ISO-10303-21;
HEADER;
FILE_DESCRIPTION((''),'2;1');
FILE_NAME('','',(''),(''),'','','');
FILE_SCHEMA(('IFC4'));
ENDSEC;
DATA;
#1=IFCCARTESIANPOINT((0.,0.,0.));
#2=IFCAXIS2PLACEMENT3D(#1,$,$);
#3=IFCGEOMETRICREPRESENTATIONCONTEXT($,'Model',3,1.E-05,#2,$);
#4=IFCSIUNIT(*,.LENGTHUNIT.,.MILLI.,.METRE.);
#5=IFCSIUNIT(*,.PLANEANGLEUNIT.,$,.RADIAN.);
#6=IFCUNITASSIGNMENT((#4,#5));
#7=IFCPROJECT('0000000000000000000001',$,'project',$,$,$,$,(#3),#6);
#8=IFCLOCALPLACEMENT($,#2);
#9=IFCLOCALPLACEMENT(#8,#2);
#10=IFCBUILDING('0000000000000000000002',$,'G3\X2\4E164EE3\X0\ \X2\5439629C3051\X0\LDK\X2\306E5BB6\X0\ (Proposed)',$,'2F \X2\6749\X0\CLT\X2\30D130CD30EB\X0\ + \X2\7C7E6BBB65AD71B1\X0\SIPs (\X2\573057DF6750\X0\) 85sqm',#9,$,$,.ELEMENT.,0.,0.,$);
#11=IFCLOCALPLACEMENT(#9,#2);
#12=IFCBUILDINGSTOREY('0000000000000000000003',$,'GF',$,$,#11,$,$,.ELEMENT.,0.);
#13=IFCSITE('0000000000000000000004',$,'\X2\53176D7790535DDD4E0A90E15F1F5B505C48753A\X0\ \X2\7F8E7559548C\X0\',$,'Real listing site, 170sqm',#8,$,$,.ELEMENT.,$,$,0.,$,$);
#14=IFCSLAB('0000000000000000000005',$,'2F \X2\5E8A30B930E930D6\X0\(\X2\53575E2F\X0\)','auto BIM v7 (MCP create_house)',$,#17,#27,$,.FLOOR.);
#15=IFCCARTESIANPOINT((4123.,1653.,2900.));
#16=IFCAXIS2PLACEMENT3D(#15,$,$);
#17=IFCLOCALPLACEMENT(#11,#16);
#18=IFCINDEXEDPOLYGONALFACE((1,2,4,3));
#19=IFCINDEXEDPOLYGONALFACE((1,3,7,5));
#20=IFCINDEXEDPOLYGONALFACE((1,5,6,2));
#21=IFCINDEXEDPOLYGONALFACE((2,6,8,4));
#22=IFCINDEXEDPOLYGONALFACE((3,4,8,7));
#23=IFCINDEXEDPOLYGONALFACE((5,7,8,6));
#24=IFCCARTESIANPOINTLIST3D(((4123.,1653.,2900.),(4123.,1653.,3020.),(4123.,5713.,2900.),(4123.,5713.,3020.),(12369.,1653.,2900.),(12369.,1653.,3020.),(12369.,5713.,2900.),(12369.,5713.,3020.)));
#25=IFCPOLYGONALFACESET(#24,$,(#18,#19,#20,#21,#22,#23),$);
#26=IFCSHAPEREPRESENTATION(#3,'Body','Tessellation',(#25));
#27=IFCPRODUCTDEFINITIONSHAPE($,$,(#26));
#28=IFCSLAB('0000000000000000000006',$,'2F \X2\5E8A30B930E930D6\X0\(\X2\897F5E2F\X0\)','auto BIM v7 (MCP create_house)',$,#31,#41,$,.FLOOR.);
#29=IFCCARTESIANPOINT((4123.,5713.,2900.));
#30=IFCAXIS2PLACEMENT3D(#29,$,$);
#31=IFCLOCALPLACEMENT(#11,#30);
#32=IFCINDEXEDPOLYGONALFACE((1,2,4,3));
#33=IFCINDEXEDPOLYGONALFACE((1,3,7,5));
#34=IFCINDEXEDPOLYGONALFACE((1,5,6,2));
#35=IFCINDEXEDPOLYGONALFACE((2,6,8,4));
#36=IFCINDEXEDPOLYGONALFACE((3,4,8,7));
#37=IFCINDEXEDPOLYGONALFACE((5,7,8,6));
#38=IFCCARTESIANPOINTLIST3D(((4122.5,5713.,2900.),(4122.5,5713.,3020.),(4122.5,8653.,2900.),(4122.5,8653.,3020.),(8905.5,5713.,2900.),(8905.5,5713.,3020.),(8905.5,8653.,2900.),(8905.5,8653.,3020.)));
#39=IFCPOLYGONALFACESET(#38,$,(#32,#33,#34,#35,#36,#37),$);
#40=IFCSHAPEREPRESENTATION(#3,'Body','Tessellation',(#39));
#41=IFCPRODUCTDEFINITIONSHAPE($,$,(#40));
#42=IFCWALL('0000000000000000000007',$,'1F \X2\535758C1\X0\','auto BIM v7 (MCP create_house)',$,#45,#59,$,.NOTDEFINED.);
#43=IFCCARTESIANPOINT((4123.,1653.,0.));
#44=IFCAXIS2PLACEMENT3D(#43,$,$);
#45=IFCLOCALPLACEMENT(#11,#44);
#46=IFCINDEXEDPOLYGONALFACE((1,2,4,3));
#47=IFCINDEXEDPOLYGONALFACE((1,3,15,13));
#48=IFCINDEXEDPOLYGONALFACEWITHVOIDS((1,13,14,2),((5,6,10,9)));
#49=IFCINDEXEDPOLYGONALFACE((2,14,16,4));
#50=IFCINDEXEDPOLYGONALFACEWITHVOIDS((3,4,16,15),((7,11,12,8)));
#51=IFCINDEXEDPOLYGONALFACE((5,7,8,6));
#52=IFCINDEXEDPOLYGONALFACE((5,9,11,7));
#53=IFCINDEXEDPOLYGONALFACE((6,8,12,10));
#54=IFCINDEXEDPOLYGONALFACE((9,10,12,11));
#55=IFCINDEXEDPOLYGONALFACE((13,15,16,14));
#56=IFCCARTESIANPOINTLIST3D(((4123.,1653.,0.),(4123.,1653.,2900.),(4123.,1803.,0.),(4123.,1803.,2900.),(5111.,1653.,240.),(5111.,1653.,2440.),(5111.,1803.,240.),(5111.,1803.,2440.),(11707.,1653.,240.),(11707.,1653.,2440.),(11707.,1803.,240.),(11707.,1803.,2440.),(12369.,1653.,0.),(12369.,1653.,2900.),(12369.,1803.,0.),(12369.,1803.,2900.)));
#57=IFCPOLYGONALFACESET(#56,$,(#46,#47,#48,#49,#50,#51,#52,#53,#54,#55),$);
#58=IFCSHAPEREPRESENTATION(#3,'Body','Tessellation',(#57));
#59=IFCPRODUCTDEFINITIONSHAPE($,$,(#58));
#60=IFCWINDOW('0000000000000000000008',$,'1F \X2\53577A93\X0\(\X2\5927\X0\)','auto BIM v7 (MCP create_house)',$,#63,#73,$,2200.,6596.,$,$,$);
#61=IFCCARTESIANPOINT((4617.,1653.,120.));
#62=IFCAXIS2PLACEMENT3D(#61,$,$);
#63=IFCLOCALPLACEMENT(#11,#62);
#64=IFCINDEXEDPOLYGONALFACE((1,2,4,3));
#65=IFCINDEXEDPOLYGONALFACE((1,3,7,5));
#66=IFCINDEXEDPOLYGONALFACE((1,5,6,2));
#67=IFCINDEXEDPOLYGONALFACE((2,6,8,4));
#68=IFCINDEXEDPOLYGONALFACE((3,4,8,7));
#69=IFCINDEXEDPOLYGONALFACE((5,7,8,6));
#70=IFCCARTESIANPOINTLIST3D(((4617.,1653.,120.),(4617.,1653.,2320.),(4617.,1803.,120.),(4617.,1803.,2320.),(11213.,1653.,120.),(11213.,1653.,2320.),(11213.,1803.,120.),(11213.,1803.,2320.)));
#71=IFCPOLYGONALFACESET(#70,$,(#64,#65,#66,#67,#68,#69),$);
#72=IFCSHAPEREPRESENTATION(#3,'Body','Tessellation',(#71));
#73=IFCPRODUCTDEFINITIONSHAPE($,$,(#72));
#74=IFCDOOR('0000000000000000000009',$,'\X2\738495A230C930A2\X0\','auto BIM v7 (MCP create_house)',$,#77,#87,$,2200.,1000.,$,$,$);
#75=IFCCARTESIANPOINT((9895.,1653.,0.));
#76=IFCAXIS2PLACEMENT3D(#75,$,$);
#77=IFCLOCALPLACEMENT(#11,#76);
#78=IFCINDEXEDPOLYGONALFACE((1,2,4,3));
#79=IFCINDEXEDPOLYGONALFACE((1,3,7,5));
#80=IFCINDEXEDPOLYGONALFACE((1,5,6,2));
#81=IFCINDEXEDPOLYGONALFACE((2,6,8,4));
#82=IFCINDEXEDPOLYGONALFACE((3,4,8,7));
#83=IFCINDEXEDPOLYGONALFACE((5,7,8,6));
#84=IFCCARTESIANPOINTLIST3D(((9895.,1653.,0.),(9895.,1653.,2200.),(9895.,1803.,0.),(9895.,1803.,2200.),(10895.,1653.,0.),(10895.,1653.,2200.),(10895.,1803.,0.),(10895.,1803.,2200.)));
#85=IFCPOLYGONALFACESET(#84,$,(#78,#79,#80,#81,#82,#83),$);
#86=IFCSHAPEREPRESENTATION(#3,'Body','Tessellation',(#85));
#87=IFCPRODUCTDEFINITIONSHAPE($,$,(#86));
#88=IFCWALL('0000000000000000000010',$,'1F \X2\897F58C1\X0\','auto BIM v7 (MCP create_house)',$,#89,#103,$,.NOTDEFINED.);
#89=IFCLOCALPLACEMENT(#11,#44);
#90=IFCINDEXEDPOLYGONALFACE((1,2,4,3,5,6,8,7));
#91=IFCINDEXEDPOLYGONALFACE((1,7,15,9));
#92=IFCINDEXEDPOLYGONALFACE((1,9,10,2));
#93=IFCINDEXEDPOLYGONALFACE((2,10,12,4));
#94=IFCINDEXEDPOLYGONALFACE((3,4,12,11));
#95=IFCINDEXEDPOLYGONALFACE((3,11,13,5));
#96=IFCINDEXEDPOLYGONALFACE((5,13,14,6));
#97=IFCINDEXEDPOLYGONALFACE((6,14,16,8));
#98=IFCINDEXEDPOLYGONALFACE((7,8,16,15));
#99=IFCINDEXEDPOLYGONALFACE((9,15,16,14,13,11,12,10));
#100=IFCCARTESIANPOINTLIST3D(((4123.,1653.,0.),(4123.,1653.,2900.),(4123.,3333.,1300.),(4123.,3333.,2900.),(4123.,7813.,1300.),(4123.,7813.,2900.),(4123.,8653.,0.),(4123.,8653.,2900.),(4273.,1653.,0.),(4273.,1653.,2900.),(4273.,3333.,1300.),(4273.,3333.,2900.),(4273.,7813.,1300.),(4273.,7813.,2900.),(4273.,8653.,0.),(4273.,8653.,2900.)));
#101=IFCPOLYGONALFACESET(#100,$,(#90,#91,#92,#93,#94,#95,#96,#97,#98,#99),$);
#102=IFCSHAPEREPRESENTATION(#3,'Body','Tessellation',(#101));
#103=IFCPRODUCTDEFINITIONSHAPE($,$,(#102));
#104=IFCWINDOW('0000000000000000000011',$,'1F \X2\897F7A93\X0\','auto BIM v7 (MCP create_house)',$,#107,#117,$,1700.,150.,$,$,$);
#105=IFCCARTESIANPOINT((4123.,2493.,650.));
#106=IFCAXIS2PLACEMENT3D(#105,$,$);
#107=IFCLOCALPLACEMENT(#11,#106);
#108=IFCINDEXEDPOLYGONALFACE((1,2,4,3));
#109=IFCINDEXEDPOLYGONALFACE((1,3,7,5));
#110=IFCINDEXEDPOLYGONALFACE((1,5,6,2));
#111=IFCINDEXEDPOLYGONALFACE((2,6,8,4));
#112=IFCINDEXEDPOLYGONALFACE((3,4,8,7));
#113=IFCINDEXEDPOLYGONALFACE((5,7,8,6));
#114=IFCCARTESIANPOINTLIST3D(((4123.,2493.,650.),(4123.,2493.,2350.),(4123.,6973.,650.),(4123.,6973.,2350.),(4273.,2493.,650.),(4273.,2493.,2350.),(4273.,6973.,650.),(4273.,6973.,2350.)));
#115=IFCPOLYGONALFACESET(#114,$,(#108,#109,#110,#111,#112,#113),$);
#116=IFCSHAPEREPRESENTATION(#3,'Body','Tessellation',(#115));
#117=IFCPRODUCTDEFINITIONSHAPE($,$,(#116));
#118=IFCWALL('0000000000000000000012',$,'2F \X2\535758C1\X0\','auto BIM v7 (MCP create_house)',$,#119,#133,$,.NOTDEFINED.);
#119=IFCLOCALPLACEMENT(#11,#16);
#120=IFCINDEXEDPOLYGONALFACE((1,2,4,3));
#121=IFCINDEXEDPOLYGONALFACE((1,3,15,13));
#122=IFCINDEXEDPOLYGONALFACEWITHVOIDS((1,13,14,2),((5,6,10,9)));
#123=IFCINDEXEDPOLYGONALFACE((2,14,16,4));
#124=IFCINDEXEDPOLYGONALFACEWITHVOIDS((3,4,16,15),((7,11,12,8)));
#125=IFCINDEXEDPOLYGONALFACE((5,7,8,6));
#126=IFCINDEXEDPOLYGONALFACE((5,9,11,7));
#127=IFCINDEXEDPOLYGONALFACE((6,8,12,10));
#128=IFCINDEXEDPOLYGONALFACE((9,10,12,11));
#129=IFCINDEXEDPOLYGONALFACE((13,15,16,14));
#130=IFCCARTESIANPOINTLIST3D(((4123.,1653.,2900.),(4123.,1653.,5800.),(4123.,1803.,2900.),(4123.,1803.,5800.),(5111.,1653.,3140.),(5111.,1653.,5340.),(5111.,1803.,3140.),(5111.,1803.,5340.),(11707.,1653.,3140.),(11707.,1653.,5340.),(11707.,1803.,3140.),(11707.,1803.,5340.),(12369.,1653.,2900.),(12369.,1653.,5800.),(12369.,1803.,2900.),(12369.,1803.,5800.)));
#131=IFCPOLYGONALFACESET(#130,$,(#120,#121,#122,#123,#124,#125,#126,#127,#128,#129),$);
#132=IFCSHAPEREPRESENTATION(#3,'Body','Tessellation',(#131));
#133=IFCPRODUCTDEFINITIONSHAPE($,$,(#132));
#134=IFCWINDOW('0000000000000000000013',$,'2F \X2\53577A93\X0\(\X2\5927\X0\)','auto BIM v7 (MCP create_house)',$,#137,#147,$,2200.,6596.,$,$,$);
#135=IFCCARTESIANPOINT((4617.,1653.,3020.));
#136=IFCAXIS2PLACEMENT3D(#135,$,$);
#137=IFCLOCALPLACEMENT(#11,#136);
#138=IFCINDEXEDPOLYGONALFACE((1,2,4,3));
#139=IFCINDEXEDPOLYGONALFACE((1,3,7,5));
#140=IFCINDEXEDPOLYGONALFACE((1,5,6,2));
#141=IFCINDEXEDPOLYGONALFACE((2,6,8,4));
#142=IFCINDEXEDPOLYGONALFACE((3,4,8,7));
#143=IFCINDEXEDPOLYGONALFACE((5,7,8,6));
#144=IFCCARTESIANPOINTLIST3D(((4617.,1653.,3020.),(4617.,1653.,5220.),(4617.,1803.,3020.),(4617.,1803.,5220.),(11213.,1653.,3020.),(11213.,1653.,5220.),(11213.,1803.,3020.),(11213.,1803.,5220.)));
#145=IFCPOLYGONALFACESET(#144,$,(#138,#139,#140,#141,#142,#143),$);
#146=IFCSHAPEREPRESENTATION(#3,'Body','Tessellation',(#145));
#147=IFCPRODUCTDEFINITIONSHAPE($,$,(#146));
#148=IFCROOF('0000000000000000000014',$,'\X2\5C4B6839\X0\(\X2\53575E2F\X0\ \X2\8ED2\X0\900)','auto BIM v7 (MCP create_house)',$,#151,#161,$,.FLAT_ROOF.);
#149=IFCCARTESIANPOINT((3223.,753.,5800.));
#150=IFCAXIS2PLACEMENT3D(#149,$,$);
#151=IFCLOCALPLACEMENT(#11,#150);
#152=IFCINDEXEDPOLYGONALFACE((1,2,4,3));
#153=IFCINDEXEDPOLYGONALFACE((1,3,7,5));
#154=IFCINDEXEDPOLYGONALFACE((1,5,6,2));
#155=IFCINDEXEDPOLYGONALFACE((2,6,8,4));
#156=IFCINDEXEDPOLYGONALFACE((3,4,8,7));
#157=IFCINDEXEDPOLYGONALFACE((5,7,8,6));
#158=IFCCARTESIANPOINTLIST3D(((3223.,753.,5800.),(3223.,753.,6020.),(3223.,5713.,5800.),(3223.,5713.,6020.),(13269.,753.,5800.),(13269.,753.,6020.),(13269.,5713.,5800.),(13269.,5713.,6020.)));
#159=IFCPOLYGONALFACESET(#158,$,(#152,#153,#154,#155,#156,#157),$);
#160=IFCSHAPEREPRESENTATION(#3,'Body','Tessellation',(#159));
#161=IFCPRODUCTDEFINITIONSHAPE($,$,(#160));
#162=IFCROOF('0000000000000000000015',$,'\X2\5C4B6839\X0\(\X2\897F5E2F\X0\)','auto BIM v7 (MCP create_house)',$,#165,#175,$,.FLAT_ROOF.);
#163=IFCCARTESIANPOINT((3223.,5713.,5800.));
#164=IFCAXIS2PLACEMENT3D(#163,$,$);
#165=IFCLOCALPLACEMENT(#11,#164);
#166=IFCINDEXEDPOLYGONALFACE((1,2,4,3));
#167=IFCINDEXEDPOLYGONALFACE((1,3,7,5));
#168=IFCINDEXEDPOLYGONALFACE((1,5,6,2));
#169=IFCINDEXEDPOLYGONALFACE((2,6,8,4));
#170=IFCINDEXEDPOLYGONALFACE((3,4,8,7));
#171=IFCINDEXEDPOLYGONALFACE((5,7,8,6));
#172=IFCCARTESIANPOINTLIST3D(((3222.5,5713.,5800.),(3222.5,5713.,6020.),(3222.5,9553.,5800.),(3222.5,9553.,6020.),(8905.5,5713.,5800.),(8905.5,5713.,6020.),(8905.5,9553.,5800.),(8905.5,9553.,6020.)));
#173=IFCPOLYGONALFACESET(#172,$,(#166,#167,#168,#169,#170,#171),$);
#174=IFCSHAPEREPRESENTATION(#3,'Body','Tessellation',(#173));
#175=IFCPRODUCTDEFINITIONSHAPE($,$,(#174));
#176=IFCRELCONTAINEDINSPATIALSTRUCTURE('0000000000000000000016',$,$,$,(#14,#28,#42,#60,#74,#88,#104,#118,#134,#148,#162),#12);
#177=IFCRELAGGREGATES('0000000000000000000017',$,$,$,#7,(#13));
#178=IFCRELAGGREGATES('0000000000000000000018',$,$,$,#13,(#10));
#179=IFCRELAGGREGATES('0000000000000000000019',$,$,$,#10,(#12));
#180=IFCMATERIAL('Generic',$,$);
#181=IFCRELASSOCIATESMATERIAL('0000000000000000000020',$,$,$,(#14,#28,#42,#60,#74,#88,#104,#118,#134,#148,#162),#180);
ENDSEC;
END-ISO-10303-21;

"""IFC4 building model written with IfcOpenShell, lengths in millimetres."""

from ifc_helpers import new_model, si_unit, frame, frame_2d, origin, place, context, project, spatial, rectangle, extrude, material, element, fill, save


model = new_model("IFC4")

# Units and contexts
model_context = context("Model", 3, precision=1e-05, world=origin())
ifc_project = project(units=[si_unit("LENGTHUNIT", "METRE", prefix="MILLI"), si_unit("PLANEANGLEUNIT", "RADIAN")], contexts=[model_context])

# Site, building, storey
site_placement = place(None, origin())
site = spatial("IfcSite", under=ifc_project, at=site_placement, Name="北海道川上郡弟子屈町 美留和", ObjectType="Real listing site, 170sqm", CompositionType="ELEMENT", RefElevation=0.0)
building_placement = place(site_placement, origin())
building = spatial("IfcBuilding", under=site, at=building_placement, Name="G3世代 吹抜けLDKの家 (Proposed)", ObjectType="2F 杉CLTパネル + 籾殻断熱SIPs (地域材) 85sqm", CompositionType="ELEMENT", ElevationOfRefHeight=0.0, ElevationOfTerrain=0.0)
storey_placement = place(building_placement, origin())
storey = spatial("IfcBuildingStorey", under=building, at=storey_placement, Name="GF", CompositionType="ELEMENT", Elevation=0.0)

# Slabs
ifc_material = material(Name="Generic")
slab_1_placement = place(storey_placement, frame((4123.0, 1653.0, 2900.0)))
element("IfcSlab", 1, at=slab_1_placement, inside=storey, material=ifc_material, Name="2F 床スラブ(南帯)", Description="auto BIM v7 (MCP create_house)", PredefinedType="FLOOR", context=model_context, shape_type="SweptSolid", body=[
    extrude(rectangle(XDim=8246.0, YDim=4060.0, at=frame_2d((4123.0, 2030.0))), frame((4123.0, 1653.0, 2900.0)), (0.0, 0.0, 1.0), 120.0),
])
slab_2_placement = place(storey_placement, frame((4123.0, 5713.0, 2900.0)))
element("IfcSlab", 2, at=slab_2_placement, inside=storey, material=ifc_material, Name="2F 床スラブ(西帯)", Description="auto BIM v7 (MCP create_house)", PredefinedType="FLOOR", context=model_context, shape_type="SweptSolid", body=[
    extrude(rectangle(XDim=4783.0, YDim=2940.0, at=frame_2d((2391.0, 1470.0))), frame((4123.0, 5713.0, 2900.0)), (0.0, 0.0, 1.0), 120.0),
])

# Wall, openings, window, door
wall_1_placement = place(storey_placement, frame((4123.0, 1653.0, 0.0)))
wall_1 = element("IfcWall", 3, at=wall_1_placement, inside=storey, material=ifc_material, Name="1F 南壁", Description="auto BIM v7 (MCP create_house)", PredefinedType="NOTDEFINED", context=model_context, shape_type="SweptSolid", body=[
    extrude(rectangle(XDim=8246.0, YDim=150.0, at=frame_2d((4123.0, 75.0))), frame((4123.0, 1653.0, 0.0)), (0.0, 0.0, 1.0), 2900.0),
])
opening_1_placement = place(storey_placement, frame((4617.0, 1653.0, 120.0)))
opening_1 = element("IfcOpeningElement", 4, at=opening_1_placement, cuts=wall_1, PredefinedType="NOTDEFINED", context=model_context, shape_type="SweptSolid", body=[
    extrude(rectangle(XDim=6596.0, YDim=150.0, at=frame_2d((3298.0, 75.0))), frame((4617.0, 1653.0, 120.0)), (0.0, 0.0, 1.0), 2200.0),
])
opening_2_placement = place(storey_placement, frame((9895.0, 1653.0, 0.0)))
opening_2 = element("IfcOpeningElement", 5, at=opening_2_placement, cuts=wall_1, PredefinedType="NOTDEFINED", context=model_context, shape_type="SweptSolid", body=[
    extrude(rectangle(XDim=1000.0, YDim=150.0, at=frame_2d((500.0, 75.0))), frame((9895.0, 1653.0, 0.0)), (0.0, 0.0, 1.0), 2200.0),
])
window_1_placement = place(storey_placement, frame((4617.0, 1653.0, 120.0)))
window_1 = element("IfcWindow", 6, at=window_1_placement, inside=storey, material=ifc_material, Name="1F 南窓(大)", Description="auto BIM v7 (MCP create_house)", OverallHeight=2200.0, OverallWidth=6596.0, context=model_context, shape_type="SweptSolid", body=[
    extrude(rectangle(XDim=6596.0, YDim=150.0, at=frame_2d((3298.0, 75.0))), frame((4617.0, 1653.0, 120.0)), (0.0, 0.0, 1.0), 2200.0),
])
fill(opening_1, window_1)
door_placement = place(storey_placement, frame((9895.0, 1653.0, 0.0)))
door = element("IfcDoor", 7, at=door_placement, inside=storey, material=ifc_material, Name="玄関ドア", Description="auto BIM v7 (MCP create_house)", OverallHeight=2200.0, OverallWidth=1000.0, context=model_context, shape_type="SweptSolid", body=[
    extrude(rectangle(XDim=1000.0, YDim=150.0, at=frame_2d((500.0, 75.0))), frame((9895.0, 1653.0, 0.0)), (0.0, 0.0, 1.0), 2200.0),
])
fill(opening_2, door)

# Wall, opening, window
wall_2_placement = place(storey_placement, frame((4123.0, 1653.0, 0.0)))
wall_2 = element("IfcWall", 8, at=wall_2_placement, inside=storey, material=ifc_material, Name="1F 西壁", Description="auto BIM v7 (MCP create_house)", PredefinedType="NOTDEFINED", context=model_context, shape_type="SweptSolid", body=[
    extrude(rectangle(XDim=150.0, YDim=7000.0, at=frame_2d((75.0, 3500.0))), frame((4123.0, 1653.0, 0.0)), (0.0, 0.0, 1.0), 2900.0),
])
opening_3_placement = place(storey_placement, frame((4123.0, 2493.0, 650.0)))
opening_3 = element("IfcOpeningElement", 9, at=opening_3_placement, cuts=wall_2, PredefinedType="NOTDEFINED", context=model_context, shape_type="SweptSolid", body=[
    extrude(rectangle(XDim=150.0, YDim=4480.0, at=frame_2d((75.0, 2240.0))), frame((4123.0, 2493.0, 650.0)), (0.0, 0.0, 1.0), 1700.0),
])
window_2_placement = place(storey_placement, frame((4123.0, 2493.0, 650.0)))
window_2 = element("IfcWindow", 10, at=window_2_placement, inside=storey, material=ifc_material, Name="1F 西窓", Description="auto BIM v7 (MCP create_house)", OverallHeight=1700.0, OverallWidth=150.0, context=model_context, shape_type="SweptSolid", body=[
    extrude(rectangle(XDim=150.0, YDim=4480.0, at=frame_2d((75.0, 2240.0))), frame((4123.0, 2493.0, 650.0)), (0.0, 0.0, 1.0), 1700.0),
])
fill(opening_3, window_2)

# Wall, opening, window
wall_3_placement = place(storey_placement, frame((4123.0, 1653.0, 2900.0)))
wall_3 = element("IfcWall", 11, at=wall_3_placement, inside=storey, material=ifc_material, Name="2F 南壁", Description="auto BIM v7 (MCP create_house)", PredefinedType="NOTDEFINED", context=model_context, shape_type="SweptSolid", body=[
    extrude(rectangle(XDim=8246.0, YDim=150.0, at=frame_2d((4123.0, 75.0))), frame((4123.0, 1653.0, 2900.0)), (0.0, 0.0, 1.0), 2900.0),
])
opening_4_placement = place(storey_placement, frame((4617.0, 1653.0, 3020.0)))
opening_4 = element("IfcOpeningElement", 12, at=opening_4_placement, cuts=wall_3, PredefinedType="NOTDEFINED", context=model_context, shape_type="SweptSolid", body=[
    extrude(rectangle(XDim=6596.0, YDim=150.0, at=frame_2d((3298.0, 75.0))), frame((4617.0, 1653.0, 3020.0)), (0.0, 0.0, 1.0), 2200.0),
])
window_3_placement = place(storey_placement, frame((4617.0, 1653.0, 3020.0)))
window_3 = element("IfcWindow", 13, at=window_3_placement, inside=storey, material=ifc_material, Name="2F 南窓(大)", Description="auto BIM v7 (MCP create_house)", OverallHeight=2200.0, OverallWidth=6596.0, context=model_context, shape_type="SweptSolid", body=[
    extrude(rectangle(XDim=6596.0, YDim=150.0, at=frame_2d((3298.0, 75.0))), frame((4617.0, 1653.0, 3020.0)), (0.0, 0.0, 1.0), 2200.0),
])
fill(opening_4, window_3)

# Roofs
roof_1_placement = place(storey_placement, frame((3223.0, 753.0, 5800.0)))
element("IfcRoof", 14, at=roof_1_placement, inside=storey, material=ifc_material, Name="屋根(南帯 軒900)", Description="auto BIM v7 (MCP create_house)", PredefinedType="FLAT_ROOF", context=model_context, shape_type="SweptSolid", body=[
    extrude(rectangle(XDim=10046.0, YDim=4960.0, at=frame_2d((5023.0, 2480.0))), frame((3223.0, 753.0, 5800.0)), (0.0, 0.0, 1.0), 220.0),
])
roof_2_placement = place(storey_placement, frame((3223.0, 5713.0, 5800.0)))
element("IfcRoof", 15, at=roof_2_placement, inside=storey, material=ifc_material, Name="屋根(西帯)", Description="auto BIM v7 (MCP create_house)", PredefinedType="FLAT_ROOF", context=model_context, shape_type="SweptSolid", body=[
    extrude(rectangle(XDim=5683.0, YDim=3840.0, at=frame_2d((2841.0, 1920.0))), frame((3223.0, 5713.0, 5800.0)), (0.0, 0.0, 1.0), 220.0),
])

save(model, "model.ifc")
